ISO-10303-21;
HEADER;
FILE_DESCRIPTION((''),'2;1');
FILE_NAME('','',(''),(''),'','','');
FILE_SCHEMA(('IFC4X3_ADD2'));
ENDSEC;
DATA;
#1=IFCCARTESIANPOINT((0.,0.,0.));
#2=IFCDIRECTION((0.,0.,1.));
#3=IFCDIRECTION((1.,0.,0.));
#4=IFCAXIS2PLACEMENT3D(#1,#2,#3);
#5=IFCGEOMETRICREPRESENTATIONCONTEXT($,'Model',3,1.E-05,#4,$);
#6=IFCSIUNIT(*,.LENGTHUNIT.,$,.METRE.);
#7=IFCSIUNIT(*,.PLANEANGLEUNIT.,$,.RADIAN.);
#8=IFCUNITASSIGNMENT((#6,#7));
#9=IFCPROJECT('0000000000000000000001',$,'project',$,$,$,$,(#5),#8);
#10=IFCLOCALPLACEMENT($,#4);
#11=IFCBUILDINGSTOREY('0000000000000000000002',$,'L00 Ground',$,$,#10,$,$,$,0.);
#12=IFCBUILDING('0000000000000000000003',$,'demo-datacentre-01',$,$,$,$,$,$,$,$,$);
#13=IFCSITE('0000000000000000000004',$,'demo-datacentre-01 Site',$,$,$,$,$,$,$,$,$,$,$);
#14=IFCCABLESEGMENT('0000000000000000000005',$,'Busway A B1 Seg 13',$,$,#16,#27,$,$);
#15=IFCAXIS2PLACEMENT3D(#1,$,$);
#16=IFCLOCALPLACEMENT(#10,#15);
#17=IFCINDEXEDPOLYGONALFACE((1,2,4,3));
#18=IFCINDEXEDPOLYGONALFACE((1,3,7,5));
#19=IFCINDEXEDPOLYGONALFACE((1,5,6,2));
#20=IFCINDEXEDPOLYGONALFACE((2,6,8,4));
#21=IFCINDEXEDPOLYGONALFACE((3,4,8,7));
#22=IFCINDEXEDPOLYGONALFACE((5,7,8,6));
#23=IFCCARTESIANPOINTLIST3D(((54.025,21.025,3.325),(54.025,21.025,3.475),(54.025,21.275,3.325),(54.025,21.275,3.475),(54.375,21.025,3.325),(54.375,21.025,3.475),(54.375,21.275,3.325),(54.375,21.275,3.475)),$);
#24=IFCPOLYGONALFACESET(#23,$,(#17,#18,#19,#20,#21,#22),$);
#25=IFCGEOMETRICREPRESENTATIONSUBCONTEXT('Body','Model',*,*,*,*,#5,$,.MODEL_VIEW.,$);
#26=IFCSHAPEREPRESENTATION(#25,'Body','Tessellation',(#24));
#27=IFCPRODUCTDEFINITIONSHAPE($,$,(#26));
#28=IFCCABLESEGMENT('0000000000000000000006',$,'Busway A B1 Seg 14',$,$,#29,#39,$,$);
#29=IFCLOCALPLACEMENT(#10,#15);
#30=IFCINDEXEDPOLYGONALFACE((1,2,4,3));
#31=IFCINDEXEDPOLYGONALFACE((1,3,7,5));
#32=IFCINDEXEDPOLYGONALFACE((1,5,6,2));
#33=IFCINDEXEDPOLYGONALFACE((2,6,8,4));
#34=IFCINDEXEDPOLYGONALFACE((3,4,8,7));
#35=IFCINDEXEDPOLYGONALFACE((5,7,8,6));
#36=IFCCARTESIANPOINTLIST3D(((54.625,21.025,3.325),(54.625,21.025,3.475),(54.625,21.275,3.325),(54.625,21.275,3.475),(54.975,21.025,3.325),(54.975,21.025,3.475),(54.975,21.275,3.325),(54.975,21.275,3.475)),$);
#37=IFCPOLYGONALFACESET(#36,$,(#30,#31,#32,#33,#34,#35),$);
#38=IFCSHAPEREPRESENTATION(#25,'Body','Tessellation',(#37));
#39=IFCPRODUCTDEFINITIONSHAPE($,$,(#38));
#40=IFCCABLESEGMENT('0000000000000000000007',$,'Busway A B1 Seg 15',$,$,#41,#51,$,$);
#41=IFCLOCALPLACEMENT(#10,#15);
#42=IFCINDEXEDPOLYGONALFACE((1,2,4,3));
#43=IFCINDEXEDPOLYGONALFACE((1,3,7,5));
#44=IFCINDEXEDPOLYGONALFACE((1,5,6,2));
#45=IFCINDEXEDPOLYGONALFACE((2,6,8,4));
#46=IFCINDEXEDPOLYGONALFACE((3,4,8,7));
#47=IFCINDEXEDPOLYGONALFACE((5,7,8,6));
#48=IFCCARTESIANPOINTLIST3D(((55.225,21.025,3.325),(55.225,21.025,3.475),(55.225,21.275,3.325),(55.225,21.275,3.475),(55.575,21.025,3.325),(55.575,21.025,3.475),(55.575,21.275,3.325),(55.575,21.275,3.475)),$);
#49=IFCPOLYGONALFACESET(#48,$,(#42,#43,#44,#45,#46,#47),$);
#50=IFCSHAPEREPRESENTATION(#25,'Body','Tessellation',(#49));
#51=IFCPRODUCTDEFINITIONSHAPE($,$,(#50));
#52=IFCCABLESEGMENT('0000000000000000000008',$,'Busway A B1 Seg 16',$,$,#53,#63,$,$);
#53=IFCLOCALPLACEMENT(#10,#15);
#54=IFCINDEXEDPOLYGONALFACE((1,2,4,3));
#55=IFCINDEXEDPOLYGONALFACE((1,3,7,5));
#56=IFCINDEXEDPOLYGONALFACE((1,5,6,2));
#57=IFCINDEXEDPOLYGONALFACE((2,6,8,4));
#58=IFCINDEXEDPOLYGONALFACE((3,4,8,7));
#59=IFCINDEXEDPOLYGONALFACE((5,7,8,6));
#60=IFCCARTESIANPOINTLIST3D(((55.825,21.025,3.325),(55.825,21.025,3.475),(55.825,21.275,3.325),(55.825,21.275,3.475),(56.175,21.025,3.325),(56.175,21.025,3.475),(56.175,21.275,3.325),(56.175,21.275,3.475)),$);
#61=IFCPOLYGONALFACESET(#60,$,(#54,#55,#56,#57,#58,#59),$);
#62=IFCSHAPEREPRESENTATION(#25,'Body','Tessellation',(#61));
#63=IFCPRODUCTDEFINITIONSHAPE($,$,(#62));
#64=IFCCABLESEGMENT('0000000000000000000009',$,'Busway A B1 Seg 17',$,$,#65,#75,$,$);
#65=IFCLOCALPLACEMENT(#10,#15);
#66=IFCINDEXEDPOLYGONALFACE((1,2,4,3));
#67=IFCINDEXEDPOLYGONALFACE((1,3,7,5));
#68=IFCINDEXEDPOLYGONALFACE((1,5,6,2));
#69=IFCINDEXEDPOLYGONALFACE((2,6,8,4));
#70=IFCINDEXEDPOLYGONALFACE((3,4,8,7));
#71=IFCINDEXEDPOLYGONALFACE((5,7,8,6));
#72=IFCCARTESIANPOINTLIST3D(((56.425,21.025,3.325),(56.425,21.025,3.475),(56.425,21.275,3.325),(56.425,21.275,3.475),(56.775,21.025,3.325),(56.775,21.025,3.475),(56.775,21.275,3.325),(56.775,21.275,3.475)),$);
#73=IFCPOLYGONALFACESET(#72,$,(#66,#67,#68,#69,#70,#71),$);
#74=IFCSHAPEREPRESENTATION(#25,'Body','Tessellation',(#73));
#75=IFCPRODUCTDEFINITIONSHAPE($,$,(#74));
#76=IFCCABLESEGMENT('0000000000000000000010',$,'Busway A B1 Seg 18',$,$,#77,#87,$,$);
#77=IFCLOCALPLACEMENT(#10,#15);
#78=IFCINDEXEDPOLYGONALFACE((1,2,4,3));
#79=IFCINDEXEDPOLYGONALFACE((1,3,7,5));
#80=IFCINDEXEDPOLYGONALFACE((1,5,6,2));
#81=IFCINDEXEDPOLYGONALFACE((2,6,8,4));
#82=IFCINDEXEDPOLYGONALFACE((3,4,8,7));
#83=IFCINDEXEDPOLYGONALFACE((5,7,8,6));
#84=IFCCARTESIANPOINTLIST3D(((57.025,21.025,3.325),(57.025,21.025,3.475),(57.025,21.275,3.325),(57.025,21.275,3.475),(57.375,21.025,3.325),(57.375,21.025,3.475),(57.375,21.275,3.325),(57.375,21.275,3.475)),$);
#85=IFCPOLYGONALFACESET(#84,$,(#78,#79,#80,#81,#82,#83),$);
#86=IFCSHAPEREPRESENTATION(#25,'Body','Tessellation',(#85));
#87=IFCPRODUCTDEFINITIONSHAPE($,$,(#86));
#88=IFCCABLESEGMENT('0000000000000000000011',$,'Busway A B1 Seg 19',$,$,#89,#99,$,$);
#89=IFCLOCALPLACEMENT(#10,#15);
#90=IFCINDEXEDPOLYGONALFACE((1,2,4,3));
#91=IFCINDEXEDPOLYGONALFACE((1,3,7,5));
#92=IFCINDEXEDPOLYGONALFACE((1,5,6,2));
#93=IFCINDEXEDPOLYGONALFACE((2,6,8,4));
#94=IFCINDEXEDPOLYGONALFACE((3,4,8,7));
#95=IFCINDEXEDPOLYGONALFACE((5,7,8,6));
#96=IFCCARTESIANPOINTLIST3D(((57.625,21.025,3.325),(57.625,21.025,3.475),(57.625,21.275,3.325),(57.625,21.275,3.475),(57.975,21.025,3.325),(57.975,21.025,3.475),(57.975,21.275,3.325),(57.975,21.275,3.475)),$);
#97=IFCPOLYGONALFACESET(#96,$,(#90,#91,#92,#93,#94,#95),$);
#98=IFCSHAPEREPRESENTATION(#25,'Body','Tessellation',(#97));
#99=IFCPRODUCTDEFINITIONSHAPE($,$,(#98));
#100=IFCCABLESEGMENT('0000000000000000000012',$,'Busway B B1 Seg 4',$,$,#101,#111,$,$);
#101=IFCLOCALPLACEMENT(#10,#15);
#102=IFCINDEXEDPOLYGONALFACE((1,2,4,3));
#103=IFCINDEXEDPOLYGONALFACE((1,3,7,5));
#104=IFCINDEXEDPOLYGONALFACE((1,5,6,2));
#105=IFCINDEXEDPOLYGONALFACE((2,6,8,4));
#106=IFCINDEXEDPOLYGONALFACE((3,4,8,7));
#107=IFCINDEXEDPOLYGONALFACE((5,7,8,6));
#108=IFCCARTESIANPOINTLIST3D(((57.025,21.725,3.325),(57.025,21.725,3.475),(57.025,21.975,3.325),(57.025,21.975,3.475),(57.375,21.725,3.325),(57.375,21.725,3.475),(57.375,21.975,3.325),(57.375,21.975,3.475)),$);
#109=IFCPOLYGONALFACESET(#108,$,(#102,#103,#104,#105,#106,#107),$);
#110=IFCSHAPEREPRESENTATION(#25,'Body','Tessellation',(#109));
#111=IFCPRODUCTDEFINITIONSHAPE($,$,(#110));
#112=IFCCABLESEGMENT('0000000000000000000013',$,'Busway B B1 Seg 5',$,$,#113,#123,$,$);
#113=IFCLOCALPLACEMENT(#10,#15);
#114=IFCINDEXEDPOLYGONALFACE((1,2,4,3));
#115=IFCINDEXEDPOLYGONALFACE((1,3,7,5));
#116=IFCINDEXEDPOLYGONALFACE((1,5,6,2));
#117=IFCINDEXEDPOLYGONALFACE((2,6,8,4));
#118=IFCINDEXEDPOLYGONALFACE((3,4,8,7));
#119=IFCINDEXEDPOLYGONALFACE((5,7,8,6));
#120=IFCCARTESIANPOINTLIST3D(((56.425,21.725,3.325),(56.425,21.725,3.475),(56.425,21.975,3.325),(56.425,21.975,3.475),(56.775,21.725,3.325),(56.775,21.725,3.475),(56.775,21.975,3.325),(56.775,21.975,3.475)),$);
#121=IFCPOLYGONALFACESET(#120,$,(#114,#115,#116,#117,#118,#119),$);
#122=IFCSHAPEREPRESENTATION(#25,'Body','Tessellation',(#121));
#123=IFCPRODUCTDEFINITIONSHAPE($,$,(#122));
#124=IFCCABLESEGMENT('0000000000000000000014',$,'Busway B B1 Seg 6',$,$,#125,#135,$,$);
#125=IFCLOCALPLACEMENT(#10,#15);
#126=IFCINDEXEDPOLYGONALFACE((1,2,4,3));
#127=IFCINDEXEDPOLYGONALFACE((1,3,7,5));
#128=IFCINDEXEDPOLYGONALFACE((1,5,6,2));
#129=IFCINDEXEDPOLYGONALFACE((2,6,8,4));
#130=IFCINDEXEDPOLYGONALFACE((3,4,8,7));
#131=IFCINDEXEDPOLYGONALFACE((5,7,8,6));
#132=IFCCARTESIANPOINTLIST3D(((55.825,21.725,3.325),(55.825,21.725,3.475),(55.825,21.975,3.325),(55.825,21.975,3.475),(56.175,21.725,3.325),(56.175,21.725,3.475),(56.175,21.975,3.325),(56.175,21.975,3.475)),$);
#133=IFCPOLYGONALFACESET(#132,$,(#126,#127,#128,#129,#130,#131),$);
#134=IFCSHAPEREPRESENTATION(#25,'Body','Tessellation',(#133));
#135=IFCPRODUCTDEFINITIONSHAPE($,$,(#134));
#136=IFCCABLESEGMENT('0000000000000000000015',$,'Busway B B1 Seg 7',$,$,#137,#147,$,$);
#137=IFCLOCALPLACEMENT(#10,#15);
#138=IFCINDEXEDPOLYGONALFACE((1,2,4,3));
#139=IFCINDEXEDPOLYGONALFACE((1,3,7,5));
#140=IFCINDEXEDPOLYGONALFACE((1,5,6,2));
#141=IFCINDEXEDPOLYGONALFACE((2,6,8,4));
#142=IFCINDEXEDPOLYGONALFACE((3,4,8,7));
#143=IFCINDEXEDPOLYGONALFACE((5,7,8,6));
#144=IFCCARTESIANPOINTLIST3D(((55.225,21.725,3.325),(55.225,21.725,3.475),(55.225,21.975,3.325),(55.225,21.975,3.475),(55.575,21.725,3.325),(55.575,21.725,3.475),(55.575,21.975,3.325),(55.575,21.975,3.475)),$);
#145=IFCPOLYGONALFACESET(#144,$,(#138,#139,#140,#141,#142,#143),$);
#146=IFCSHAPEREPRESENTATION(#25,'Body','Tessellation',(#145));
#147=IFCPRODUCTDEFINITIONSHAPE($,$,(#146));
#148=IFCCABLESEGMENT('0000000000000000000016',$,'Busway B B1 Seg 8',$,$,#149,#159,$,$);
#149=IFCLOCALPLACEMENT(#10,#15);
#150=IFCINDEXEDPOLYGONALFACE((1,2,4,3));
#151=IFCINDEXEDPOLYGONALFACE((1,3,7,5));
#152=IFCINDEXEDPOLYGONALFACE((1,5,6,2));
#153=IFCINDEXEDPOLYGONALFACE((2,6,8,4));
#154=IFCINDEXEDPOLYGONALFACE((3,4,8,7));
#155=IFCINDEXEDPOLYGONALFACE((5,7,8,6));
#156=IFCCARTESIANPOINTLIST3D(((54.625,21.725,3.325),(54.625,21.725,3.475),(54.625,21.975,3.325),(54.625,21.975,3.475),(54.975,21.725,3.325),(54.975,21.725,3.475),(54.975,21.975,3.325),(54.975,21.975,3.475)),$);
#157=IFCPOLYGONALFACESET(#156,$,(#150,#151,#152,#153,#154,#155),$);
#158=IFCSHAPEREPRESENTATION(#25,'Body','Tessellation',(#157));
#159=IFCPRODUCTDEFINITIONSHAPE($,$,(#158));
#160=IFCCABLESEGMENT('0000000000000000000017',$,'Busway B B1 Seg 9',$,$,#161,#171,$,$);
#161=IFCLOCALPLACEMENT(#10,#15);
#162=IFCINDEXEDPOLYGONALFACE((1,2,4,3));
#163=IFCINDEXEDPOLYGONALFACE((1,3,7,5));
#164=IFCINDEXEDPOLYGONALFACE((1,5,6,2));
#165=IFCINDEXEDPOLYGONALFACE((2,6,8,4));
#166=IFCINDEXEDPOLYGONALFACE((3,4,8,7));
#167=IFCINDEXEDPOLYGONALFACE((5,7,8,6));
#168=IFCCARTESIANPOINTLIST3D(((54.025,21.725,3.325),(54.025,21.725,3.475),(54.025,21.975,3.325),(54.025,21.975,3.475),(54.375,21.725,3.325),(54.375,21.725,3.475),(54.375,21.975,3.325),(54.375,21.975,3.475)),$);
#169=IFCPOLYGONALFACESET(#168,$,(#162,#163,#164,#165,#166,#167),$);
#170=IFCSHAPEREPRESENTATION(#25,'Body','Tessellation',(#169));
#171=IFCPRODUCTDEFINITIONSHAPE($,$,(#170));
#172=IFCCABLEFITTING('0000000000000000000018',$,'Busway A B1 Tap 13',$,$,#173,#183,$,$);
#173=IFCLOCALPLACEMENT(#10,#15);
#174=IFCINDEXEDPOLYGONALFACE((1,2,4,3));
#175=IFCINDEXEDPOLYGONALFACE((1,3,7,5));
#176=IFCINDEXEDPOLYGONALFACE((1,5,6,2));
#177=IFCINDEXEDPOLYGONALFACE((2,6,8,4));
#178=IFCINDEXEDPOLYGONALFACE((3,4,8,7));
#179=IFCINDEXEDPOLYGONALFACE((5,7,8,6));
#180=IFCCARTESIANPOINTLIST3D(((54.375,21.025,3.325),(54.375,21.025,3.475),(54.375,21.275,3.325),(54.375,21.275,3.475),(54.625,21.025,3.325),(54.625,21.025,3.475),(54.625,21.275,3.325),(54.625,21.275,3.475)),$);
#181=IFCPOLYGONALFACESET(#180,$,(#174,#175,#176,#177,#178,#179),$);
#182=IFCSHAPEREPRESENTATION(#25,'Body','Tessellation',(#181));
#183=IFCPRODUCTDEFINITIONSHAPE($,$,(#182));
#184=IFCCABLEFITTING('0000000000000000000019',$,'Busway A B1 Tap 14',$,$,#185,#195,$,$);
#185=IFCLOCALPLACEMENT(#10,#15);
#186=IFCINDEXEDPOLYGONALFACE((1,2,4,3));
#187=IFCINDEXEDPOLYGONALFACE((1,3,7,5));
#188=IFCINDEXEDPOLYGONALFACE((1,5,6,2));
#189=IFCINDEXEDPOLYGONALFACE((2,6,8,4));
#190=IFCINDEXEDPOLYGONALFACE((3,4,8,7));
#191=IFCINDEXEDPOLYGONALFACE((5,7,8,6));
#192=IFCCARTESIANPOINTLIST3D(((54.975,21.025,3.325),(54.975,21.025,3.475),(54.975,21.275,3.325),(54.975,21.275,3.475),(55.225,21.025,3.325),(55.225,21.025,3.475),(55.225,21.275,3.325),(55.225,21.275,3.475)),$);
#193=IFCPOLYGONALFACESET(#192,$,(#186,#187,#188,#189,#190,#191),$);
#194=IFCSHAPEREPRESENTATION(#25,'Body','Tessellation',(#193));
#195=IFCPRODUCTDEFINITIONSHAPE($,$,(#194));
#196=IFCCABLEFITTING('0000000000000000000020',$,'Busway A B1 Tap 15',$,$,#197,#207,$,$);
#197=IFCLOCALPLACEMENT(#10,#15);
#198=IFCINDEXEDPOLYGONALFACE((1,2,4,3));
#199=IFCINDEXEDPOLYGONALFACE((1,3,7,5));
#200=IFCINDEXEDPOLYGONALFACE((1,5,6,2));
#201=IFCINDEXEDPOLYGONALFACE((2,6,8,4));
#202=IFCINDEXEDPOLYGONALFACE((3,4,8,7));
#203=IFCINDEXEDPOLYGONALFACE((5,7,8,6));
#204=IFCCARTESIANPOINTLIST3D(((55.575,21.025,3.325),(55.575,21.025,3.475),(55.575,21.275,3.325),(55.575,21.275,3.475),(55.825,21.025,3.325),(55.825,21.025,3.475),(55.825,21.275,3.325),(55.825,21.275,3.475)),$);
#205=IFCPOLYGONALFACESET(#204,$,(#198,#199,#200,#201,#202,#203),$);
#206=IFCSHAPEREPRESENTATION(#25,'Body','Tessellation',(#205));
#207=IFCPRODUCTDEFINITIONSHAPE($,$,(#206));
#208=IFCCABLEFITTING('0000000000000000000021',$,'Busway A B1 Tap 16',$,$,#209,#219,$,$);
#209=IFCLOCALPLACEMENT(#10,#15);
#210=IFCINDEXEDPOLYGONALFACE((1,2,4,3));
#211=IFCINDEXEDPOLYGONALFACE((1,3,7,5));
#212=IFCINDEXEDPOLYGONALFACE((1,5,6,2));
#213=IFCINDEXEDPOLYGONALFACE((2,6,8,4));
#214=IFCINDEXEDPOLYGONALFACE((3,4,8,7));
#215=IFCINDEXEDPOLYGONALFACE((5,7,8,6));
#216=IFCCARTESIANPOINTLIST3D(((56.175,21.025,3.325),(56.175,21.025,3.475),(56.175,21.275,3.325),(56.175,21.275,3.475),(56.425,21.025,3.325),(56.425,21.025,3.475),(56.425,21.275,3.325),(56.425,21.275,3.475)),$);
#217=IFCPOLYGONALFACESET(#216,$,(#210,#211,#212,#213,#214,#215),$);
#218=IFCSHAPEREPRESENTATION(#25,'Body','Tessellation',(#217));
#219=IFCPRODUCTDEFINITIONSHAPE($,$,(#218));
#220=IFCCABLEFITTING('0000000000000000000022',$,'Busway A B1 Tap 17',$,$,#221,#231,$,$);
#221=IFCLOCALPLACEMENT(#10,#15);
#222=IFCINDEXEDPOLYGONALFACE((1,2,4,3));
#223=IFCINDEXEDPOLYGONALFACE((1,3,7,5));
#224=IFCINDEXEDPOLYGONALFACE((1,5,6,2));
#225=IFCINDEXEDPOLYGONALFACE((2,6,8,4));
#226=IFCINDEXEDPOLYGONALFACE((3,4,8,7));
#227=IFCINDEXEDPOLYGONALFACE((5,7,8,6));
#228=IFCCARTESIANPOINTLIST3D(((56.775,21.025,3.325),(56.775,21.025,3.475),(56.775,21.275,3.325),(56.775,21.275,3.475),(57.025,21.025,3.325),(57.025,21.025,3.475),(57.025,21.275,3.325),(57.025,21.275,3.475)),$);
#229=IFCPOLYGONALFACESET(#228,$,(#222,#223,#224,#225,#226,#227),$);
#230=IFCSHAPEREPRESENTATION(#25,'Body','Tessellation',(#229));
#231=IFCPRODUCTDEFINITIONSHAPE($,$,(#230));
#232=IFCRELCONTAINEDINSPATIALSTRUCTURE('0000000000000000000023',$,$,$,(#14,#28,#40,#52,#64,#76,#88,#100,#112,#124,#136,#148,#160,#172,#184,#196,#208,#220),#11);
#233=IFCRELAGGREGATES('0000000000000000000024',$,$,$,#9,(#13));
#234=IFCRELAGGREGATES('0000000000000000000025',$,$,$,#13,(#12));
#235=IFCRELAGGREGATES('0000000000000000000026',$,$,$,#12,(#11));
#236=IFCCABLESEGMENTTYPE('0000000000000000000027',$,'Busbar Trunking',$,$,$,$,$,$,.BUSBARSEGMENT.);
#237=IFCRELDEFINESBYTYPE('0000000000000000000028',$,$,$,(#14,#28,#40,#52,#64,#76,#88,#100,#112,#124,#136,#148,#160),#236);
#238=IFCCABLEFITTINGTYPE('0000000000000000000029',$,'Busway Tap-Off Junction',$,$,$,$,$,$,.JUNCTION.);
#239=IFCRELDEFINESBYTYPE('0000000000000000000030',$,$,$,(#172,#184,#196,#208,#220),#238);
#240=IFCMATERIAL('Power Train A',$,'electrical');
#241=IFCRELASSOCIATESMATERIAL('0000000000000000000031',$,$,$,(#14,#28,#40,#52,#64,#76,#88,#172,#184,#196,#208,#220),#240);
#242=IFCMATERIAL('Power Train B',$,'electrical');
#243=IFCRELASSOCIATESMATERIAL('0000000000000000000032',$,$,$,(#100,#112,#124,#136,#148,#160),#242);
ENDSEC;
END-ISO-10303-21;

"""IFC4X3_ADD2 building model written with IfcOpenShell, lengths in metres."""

from ifc_helpers import new_model, si_unit, frame, origin_with_axes, place, context, subcontext, project, spatial, rectangle, extrude, material, type_object, element, save


model = new_model("IFC4X3_ADD2")

# Units and contexts
model_context = context("Model", 3, precision=1e-05, world=origin_with_axes())
body_context = subcontext(model_context, "Body", "Model", "MODEL_VIEW")
ifc_project = project(units=[si_unit("LENGTHUNIT", "METRE"), si_unit("PLANEANGLEUNIT", "RADIAN")], contexts=[model_context])

# Site, building, storey
site = spatial("IfcSite", under=ifc_project, Name="demo-datacentre-01 Site")
building = spatial("IfcBuilding", under=site, Name="demo-datacentre-01")
storey_placement = place(None, origin_with_axes())
storey = spatial("IfcBuildingStorey", under=building, at=storey_placement, Name="L00 Ground", Elevation=0.0)

# Cable segments
ifc_material_1 = material(Name="Power Train A", Category="electrical")
cable_segment_type_1 = type_object("IfcCableSegmentType", Name="Busbar Trunking", PredefinedType="BUSBARSEGMENT")
cable_segment_1_placement = place(storey_placement, frame((54.025, 21.15, 3.4), z_axis=(1.0, 0.0, 0.0), x_axis=(0.0, 1.0, 0.0)))
element("IfcCableSegment", 1, at=cable_segment_1_placement, inside=storey, type_object=cable_segment_type_1, material=ifc_material_1, Name="Busway A B1 Seg 13", context=body_context, shape_type="SweptSolid", body=[
    extrude(rectangle(XDim=0.25, YDim=0.15), origin_with_axes(), (0.0, 0.0, 1.0), 0.35),
])
cable_segment_2_placement = place(storey_placement, frame((54.625, 21.15, 3.4), z_axis=(1.0, 0.0, 0.0), x_axis=(0.0, 1.0, 0.0)))
element("IfcCableSegment", 2, at=cable_segment_2_placement, inside=storey, type_object=cable_segment_type_1, material=ifc_material_1, Name="Busway A B1 Seg 14", context=body_context, shape_type="SweptSolid", body=[
    extrude(rectangle(XDim=0.25, YDim=0.15), origin_with_axes(), (0.0, 0.0, 1.0), 0.35),
])
for number, where, z_axis, x_axis, name in (
    (3, (55.225, 21.15, 3.4), (1.0, 0.0, 0.0), (0.0, 1.0, 0.0), "Busway A B1 Seg 15"),
    (4, (55.825, 21.15, 3.4), (1.0, 0.0, 0.0), (0.0, 1.0, 0.0), "Busway A B1 Seg 16"),
    (5, (56.425, 21.15, 3.4), (1.0, 0.0, 0.0), (0.0, 1.0, 0.0), "Busway A B1 Seg 17"),
    (6, (57.025, 21.15, 3.4), (1.0, 0.0, 0.0), (0.0, 1.0, 0.0), "Busway A B1 Seg 18"),
):
    element("IfcCableSegment", number, at=place(storey_placement, frame(where, z_axis=z_axis, x_axis=x_axis)), inside=storey, type_object=cable_segment_type_1, material=ifc_material_1, Name=name, context=body_context, shape_type="SweptSolid", body=[
        extrude(rectangle(XDim=0.25, YDim=0.15), origin_with_axes(), (0.0, 0.0, 1.0), 0.35),
    ])
cable_segment_3_placement = place(storey_placement, frame((57.625, 21.15, 3.4), z_axis=(1.0, 0.0, 0.0), x_axis=(0.0, 1.0, 0.0)))
element("IfcCableSegment", 7, at=cable_segment_3_placement, inside=storey, type_object=cable_segment_type_1, material=ifc_material_1, Name="Busway A B1 Seg 19", context=body_context, shape_type="SweptSolid", body=[
    extrude(rectangle(XDim=0.25, YDim=0.15), origin_with_axes(), (0.0, 0.0, 1.0), 0.35),
])
ifc_material_2 = material(Name="Power Train B", Category="electrical")
for number, where, z_axis, x_axis, name in (
    (8, (57.375, 21.85, 3.4), (-1.0, 0.0, 0.0), (0.0, -1.0, 0.0), "Busway B B1 Seg 4"),
    (9, (56.775, 21.85, 3.4), (-1.0, 0.0, 0.0), (0.0, -1.0, 0.0), "Busway B B1 Seg 5"),
    (10, (56.175, 21.85, 3.4), (-1.0, 0.0, 0.0), (0.0, -1.0, 0.0), "Busway B B1 Seg 6"),
    (11, (55.575, 21.85, 3.4), (-1.0, 0.0, 0.0), (0.0, -1.0, 0.0), "Busway B B1 Seg 7"),
):
    element("IfcCableSegment", number, at=place(storey_placement, frame(where, z_axis=z_axis, x_axis=x_axis)), inside=storey, type_object=cable_segment_type_1, material=ifc_material_2, Name=name, context=body_context, shape_type="SweptSolid", body=[
        extrude(rectangle(XDim=0.25, YDim=0.15), origin_with_axes(), (0.0, 0.0, 1.0), 0.35),
    ])
cable_segment_4_placement = place(storey_placement, frame((54.975, 21.85, 3.4), z_axis=(-1.0, 0.0, 0.0), x_axis=(0.0, -1.0, 0.0)))
element("IfcCableSegment", 12, at=cable_segment_4_placement, inside=storey, type_object=cable_segment_type_1, material=ifc_material_2, Name="Busway B B1 Seg 8", context=body_context, shape_type="SweptSolid", body=[
    extrude(rectangle(XDim=0.25, YDim=0.15), origin_with_axes(), (0.0, 0.0, 1.0), 0.35),
])
cable_segment_5_placement = place(storey_placement, frame((54.375, 21.85, 3.4), z_axis=(-1.0, 0.0, 0.0), x_axis=(0.0, -1.0, 0.0)))
element("IfcCableSegment", 13, at=cable_segment_5_placement, inside=storey, type_object=cable_segment_type_1, material=ifc_material_2, Name="Busway B B1 Seg 9", context=body_context, shape_type="SweptSolid", body=[
    extrude(rectangle(XDim=0.25, YDim=0.15), origin_with_axes(), (0.0, 0.0, 1.0), 0.35),
])

# Cable fittings
cable_fitting_type = type_object("IfcCableFittingType", Name="Busway Tap-Off Junction", PredefinedType="JUNCTION")
for number, where, z_axis, x_axis, name in (
    (14, (54.5, 21.15, 3.325), (0.0, 0.0, 1.0), (1.0, 0.0, 0.0), "Busway A B1 Tap 13"),
    (15, (55.1, 21.15, 3.325), (0.0, 0.0, 1.0), (1.0, 0.0, 0.0), "Busway A B1 Tap 14"),
    (16, (55.7, 21.15, 3.325), (0.0, 0.0, 1.0), (1.0, 0.0, 0.0), "Busway A B1 Tap 15"),
    (17, (56.3, 21.15, 3.325), (0.0, 0.0, 1.0), (1.0, 0.0, 0.0), "Busway A B1 Tap 16"),
    (18, (56.9, 21.15, 3.325), (0.0, 0.0, 1.0), (1.0, 0.0, 0.0), "Busway A B1 Tap 17"),
):
    element("IfcCableFitting", number, at=place(storey_placement, frame(where, z_axis=z_axis, x_axis=x_axis)), inside=storey, type_object=cable_fitting_type, material=ifc_material_1, Name=name, context=body_context, shape_type="SweptSolid", body=[
        extrude(rectangle(XDim=0.25, YDim=0.25), origin_with_axes(), (0.0, 0.0, 1.0), 0.15),
    ])

save(model, "model.ifc")
